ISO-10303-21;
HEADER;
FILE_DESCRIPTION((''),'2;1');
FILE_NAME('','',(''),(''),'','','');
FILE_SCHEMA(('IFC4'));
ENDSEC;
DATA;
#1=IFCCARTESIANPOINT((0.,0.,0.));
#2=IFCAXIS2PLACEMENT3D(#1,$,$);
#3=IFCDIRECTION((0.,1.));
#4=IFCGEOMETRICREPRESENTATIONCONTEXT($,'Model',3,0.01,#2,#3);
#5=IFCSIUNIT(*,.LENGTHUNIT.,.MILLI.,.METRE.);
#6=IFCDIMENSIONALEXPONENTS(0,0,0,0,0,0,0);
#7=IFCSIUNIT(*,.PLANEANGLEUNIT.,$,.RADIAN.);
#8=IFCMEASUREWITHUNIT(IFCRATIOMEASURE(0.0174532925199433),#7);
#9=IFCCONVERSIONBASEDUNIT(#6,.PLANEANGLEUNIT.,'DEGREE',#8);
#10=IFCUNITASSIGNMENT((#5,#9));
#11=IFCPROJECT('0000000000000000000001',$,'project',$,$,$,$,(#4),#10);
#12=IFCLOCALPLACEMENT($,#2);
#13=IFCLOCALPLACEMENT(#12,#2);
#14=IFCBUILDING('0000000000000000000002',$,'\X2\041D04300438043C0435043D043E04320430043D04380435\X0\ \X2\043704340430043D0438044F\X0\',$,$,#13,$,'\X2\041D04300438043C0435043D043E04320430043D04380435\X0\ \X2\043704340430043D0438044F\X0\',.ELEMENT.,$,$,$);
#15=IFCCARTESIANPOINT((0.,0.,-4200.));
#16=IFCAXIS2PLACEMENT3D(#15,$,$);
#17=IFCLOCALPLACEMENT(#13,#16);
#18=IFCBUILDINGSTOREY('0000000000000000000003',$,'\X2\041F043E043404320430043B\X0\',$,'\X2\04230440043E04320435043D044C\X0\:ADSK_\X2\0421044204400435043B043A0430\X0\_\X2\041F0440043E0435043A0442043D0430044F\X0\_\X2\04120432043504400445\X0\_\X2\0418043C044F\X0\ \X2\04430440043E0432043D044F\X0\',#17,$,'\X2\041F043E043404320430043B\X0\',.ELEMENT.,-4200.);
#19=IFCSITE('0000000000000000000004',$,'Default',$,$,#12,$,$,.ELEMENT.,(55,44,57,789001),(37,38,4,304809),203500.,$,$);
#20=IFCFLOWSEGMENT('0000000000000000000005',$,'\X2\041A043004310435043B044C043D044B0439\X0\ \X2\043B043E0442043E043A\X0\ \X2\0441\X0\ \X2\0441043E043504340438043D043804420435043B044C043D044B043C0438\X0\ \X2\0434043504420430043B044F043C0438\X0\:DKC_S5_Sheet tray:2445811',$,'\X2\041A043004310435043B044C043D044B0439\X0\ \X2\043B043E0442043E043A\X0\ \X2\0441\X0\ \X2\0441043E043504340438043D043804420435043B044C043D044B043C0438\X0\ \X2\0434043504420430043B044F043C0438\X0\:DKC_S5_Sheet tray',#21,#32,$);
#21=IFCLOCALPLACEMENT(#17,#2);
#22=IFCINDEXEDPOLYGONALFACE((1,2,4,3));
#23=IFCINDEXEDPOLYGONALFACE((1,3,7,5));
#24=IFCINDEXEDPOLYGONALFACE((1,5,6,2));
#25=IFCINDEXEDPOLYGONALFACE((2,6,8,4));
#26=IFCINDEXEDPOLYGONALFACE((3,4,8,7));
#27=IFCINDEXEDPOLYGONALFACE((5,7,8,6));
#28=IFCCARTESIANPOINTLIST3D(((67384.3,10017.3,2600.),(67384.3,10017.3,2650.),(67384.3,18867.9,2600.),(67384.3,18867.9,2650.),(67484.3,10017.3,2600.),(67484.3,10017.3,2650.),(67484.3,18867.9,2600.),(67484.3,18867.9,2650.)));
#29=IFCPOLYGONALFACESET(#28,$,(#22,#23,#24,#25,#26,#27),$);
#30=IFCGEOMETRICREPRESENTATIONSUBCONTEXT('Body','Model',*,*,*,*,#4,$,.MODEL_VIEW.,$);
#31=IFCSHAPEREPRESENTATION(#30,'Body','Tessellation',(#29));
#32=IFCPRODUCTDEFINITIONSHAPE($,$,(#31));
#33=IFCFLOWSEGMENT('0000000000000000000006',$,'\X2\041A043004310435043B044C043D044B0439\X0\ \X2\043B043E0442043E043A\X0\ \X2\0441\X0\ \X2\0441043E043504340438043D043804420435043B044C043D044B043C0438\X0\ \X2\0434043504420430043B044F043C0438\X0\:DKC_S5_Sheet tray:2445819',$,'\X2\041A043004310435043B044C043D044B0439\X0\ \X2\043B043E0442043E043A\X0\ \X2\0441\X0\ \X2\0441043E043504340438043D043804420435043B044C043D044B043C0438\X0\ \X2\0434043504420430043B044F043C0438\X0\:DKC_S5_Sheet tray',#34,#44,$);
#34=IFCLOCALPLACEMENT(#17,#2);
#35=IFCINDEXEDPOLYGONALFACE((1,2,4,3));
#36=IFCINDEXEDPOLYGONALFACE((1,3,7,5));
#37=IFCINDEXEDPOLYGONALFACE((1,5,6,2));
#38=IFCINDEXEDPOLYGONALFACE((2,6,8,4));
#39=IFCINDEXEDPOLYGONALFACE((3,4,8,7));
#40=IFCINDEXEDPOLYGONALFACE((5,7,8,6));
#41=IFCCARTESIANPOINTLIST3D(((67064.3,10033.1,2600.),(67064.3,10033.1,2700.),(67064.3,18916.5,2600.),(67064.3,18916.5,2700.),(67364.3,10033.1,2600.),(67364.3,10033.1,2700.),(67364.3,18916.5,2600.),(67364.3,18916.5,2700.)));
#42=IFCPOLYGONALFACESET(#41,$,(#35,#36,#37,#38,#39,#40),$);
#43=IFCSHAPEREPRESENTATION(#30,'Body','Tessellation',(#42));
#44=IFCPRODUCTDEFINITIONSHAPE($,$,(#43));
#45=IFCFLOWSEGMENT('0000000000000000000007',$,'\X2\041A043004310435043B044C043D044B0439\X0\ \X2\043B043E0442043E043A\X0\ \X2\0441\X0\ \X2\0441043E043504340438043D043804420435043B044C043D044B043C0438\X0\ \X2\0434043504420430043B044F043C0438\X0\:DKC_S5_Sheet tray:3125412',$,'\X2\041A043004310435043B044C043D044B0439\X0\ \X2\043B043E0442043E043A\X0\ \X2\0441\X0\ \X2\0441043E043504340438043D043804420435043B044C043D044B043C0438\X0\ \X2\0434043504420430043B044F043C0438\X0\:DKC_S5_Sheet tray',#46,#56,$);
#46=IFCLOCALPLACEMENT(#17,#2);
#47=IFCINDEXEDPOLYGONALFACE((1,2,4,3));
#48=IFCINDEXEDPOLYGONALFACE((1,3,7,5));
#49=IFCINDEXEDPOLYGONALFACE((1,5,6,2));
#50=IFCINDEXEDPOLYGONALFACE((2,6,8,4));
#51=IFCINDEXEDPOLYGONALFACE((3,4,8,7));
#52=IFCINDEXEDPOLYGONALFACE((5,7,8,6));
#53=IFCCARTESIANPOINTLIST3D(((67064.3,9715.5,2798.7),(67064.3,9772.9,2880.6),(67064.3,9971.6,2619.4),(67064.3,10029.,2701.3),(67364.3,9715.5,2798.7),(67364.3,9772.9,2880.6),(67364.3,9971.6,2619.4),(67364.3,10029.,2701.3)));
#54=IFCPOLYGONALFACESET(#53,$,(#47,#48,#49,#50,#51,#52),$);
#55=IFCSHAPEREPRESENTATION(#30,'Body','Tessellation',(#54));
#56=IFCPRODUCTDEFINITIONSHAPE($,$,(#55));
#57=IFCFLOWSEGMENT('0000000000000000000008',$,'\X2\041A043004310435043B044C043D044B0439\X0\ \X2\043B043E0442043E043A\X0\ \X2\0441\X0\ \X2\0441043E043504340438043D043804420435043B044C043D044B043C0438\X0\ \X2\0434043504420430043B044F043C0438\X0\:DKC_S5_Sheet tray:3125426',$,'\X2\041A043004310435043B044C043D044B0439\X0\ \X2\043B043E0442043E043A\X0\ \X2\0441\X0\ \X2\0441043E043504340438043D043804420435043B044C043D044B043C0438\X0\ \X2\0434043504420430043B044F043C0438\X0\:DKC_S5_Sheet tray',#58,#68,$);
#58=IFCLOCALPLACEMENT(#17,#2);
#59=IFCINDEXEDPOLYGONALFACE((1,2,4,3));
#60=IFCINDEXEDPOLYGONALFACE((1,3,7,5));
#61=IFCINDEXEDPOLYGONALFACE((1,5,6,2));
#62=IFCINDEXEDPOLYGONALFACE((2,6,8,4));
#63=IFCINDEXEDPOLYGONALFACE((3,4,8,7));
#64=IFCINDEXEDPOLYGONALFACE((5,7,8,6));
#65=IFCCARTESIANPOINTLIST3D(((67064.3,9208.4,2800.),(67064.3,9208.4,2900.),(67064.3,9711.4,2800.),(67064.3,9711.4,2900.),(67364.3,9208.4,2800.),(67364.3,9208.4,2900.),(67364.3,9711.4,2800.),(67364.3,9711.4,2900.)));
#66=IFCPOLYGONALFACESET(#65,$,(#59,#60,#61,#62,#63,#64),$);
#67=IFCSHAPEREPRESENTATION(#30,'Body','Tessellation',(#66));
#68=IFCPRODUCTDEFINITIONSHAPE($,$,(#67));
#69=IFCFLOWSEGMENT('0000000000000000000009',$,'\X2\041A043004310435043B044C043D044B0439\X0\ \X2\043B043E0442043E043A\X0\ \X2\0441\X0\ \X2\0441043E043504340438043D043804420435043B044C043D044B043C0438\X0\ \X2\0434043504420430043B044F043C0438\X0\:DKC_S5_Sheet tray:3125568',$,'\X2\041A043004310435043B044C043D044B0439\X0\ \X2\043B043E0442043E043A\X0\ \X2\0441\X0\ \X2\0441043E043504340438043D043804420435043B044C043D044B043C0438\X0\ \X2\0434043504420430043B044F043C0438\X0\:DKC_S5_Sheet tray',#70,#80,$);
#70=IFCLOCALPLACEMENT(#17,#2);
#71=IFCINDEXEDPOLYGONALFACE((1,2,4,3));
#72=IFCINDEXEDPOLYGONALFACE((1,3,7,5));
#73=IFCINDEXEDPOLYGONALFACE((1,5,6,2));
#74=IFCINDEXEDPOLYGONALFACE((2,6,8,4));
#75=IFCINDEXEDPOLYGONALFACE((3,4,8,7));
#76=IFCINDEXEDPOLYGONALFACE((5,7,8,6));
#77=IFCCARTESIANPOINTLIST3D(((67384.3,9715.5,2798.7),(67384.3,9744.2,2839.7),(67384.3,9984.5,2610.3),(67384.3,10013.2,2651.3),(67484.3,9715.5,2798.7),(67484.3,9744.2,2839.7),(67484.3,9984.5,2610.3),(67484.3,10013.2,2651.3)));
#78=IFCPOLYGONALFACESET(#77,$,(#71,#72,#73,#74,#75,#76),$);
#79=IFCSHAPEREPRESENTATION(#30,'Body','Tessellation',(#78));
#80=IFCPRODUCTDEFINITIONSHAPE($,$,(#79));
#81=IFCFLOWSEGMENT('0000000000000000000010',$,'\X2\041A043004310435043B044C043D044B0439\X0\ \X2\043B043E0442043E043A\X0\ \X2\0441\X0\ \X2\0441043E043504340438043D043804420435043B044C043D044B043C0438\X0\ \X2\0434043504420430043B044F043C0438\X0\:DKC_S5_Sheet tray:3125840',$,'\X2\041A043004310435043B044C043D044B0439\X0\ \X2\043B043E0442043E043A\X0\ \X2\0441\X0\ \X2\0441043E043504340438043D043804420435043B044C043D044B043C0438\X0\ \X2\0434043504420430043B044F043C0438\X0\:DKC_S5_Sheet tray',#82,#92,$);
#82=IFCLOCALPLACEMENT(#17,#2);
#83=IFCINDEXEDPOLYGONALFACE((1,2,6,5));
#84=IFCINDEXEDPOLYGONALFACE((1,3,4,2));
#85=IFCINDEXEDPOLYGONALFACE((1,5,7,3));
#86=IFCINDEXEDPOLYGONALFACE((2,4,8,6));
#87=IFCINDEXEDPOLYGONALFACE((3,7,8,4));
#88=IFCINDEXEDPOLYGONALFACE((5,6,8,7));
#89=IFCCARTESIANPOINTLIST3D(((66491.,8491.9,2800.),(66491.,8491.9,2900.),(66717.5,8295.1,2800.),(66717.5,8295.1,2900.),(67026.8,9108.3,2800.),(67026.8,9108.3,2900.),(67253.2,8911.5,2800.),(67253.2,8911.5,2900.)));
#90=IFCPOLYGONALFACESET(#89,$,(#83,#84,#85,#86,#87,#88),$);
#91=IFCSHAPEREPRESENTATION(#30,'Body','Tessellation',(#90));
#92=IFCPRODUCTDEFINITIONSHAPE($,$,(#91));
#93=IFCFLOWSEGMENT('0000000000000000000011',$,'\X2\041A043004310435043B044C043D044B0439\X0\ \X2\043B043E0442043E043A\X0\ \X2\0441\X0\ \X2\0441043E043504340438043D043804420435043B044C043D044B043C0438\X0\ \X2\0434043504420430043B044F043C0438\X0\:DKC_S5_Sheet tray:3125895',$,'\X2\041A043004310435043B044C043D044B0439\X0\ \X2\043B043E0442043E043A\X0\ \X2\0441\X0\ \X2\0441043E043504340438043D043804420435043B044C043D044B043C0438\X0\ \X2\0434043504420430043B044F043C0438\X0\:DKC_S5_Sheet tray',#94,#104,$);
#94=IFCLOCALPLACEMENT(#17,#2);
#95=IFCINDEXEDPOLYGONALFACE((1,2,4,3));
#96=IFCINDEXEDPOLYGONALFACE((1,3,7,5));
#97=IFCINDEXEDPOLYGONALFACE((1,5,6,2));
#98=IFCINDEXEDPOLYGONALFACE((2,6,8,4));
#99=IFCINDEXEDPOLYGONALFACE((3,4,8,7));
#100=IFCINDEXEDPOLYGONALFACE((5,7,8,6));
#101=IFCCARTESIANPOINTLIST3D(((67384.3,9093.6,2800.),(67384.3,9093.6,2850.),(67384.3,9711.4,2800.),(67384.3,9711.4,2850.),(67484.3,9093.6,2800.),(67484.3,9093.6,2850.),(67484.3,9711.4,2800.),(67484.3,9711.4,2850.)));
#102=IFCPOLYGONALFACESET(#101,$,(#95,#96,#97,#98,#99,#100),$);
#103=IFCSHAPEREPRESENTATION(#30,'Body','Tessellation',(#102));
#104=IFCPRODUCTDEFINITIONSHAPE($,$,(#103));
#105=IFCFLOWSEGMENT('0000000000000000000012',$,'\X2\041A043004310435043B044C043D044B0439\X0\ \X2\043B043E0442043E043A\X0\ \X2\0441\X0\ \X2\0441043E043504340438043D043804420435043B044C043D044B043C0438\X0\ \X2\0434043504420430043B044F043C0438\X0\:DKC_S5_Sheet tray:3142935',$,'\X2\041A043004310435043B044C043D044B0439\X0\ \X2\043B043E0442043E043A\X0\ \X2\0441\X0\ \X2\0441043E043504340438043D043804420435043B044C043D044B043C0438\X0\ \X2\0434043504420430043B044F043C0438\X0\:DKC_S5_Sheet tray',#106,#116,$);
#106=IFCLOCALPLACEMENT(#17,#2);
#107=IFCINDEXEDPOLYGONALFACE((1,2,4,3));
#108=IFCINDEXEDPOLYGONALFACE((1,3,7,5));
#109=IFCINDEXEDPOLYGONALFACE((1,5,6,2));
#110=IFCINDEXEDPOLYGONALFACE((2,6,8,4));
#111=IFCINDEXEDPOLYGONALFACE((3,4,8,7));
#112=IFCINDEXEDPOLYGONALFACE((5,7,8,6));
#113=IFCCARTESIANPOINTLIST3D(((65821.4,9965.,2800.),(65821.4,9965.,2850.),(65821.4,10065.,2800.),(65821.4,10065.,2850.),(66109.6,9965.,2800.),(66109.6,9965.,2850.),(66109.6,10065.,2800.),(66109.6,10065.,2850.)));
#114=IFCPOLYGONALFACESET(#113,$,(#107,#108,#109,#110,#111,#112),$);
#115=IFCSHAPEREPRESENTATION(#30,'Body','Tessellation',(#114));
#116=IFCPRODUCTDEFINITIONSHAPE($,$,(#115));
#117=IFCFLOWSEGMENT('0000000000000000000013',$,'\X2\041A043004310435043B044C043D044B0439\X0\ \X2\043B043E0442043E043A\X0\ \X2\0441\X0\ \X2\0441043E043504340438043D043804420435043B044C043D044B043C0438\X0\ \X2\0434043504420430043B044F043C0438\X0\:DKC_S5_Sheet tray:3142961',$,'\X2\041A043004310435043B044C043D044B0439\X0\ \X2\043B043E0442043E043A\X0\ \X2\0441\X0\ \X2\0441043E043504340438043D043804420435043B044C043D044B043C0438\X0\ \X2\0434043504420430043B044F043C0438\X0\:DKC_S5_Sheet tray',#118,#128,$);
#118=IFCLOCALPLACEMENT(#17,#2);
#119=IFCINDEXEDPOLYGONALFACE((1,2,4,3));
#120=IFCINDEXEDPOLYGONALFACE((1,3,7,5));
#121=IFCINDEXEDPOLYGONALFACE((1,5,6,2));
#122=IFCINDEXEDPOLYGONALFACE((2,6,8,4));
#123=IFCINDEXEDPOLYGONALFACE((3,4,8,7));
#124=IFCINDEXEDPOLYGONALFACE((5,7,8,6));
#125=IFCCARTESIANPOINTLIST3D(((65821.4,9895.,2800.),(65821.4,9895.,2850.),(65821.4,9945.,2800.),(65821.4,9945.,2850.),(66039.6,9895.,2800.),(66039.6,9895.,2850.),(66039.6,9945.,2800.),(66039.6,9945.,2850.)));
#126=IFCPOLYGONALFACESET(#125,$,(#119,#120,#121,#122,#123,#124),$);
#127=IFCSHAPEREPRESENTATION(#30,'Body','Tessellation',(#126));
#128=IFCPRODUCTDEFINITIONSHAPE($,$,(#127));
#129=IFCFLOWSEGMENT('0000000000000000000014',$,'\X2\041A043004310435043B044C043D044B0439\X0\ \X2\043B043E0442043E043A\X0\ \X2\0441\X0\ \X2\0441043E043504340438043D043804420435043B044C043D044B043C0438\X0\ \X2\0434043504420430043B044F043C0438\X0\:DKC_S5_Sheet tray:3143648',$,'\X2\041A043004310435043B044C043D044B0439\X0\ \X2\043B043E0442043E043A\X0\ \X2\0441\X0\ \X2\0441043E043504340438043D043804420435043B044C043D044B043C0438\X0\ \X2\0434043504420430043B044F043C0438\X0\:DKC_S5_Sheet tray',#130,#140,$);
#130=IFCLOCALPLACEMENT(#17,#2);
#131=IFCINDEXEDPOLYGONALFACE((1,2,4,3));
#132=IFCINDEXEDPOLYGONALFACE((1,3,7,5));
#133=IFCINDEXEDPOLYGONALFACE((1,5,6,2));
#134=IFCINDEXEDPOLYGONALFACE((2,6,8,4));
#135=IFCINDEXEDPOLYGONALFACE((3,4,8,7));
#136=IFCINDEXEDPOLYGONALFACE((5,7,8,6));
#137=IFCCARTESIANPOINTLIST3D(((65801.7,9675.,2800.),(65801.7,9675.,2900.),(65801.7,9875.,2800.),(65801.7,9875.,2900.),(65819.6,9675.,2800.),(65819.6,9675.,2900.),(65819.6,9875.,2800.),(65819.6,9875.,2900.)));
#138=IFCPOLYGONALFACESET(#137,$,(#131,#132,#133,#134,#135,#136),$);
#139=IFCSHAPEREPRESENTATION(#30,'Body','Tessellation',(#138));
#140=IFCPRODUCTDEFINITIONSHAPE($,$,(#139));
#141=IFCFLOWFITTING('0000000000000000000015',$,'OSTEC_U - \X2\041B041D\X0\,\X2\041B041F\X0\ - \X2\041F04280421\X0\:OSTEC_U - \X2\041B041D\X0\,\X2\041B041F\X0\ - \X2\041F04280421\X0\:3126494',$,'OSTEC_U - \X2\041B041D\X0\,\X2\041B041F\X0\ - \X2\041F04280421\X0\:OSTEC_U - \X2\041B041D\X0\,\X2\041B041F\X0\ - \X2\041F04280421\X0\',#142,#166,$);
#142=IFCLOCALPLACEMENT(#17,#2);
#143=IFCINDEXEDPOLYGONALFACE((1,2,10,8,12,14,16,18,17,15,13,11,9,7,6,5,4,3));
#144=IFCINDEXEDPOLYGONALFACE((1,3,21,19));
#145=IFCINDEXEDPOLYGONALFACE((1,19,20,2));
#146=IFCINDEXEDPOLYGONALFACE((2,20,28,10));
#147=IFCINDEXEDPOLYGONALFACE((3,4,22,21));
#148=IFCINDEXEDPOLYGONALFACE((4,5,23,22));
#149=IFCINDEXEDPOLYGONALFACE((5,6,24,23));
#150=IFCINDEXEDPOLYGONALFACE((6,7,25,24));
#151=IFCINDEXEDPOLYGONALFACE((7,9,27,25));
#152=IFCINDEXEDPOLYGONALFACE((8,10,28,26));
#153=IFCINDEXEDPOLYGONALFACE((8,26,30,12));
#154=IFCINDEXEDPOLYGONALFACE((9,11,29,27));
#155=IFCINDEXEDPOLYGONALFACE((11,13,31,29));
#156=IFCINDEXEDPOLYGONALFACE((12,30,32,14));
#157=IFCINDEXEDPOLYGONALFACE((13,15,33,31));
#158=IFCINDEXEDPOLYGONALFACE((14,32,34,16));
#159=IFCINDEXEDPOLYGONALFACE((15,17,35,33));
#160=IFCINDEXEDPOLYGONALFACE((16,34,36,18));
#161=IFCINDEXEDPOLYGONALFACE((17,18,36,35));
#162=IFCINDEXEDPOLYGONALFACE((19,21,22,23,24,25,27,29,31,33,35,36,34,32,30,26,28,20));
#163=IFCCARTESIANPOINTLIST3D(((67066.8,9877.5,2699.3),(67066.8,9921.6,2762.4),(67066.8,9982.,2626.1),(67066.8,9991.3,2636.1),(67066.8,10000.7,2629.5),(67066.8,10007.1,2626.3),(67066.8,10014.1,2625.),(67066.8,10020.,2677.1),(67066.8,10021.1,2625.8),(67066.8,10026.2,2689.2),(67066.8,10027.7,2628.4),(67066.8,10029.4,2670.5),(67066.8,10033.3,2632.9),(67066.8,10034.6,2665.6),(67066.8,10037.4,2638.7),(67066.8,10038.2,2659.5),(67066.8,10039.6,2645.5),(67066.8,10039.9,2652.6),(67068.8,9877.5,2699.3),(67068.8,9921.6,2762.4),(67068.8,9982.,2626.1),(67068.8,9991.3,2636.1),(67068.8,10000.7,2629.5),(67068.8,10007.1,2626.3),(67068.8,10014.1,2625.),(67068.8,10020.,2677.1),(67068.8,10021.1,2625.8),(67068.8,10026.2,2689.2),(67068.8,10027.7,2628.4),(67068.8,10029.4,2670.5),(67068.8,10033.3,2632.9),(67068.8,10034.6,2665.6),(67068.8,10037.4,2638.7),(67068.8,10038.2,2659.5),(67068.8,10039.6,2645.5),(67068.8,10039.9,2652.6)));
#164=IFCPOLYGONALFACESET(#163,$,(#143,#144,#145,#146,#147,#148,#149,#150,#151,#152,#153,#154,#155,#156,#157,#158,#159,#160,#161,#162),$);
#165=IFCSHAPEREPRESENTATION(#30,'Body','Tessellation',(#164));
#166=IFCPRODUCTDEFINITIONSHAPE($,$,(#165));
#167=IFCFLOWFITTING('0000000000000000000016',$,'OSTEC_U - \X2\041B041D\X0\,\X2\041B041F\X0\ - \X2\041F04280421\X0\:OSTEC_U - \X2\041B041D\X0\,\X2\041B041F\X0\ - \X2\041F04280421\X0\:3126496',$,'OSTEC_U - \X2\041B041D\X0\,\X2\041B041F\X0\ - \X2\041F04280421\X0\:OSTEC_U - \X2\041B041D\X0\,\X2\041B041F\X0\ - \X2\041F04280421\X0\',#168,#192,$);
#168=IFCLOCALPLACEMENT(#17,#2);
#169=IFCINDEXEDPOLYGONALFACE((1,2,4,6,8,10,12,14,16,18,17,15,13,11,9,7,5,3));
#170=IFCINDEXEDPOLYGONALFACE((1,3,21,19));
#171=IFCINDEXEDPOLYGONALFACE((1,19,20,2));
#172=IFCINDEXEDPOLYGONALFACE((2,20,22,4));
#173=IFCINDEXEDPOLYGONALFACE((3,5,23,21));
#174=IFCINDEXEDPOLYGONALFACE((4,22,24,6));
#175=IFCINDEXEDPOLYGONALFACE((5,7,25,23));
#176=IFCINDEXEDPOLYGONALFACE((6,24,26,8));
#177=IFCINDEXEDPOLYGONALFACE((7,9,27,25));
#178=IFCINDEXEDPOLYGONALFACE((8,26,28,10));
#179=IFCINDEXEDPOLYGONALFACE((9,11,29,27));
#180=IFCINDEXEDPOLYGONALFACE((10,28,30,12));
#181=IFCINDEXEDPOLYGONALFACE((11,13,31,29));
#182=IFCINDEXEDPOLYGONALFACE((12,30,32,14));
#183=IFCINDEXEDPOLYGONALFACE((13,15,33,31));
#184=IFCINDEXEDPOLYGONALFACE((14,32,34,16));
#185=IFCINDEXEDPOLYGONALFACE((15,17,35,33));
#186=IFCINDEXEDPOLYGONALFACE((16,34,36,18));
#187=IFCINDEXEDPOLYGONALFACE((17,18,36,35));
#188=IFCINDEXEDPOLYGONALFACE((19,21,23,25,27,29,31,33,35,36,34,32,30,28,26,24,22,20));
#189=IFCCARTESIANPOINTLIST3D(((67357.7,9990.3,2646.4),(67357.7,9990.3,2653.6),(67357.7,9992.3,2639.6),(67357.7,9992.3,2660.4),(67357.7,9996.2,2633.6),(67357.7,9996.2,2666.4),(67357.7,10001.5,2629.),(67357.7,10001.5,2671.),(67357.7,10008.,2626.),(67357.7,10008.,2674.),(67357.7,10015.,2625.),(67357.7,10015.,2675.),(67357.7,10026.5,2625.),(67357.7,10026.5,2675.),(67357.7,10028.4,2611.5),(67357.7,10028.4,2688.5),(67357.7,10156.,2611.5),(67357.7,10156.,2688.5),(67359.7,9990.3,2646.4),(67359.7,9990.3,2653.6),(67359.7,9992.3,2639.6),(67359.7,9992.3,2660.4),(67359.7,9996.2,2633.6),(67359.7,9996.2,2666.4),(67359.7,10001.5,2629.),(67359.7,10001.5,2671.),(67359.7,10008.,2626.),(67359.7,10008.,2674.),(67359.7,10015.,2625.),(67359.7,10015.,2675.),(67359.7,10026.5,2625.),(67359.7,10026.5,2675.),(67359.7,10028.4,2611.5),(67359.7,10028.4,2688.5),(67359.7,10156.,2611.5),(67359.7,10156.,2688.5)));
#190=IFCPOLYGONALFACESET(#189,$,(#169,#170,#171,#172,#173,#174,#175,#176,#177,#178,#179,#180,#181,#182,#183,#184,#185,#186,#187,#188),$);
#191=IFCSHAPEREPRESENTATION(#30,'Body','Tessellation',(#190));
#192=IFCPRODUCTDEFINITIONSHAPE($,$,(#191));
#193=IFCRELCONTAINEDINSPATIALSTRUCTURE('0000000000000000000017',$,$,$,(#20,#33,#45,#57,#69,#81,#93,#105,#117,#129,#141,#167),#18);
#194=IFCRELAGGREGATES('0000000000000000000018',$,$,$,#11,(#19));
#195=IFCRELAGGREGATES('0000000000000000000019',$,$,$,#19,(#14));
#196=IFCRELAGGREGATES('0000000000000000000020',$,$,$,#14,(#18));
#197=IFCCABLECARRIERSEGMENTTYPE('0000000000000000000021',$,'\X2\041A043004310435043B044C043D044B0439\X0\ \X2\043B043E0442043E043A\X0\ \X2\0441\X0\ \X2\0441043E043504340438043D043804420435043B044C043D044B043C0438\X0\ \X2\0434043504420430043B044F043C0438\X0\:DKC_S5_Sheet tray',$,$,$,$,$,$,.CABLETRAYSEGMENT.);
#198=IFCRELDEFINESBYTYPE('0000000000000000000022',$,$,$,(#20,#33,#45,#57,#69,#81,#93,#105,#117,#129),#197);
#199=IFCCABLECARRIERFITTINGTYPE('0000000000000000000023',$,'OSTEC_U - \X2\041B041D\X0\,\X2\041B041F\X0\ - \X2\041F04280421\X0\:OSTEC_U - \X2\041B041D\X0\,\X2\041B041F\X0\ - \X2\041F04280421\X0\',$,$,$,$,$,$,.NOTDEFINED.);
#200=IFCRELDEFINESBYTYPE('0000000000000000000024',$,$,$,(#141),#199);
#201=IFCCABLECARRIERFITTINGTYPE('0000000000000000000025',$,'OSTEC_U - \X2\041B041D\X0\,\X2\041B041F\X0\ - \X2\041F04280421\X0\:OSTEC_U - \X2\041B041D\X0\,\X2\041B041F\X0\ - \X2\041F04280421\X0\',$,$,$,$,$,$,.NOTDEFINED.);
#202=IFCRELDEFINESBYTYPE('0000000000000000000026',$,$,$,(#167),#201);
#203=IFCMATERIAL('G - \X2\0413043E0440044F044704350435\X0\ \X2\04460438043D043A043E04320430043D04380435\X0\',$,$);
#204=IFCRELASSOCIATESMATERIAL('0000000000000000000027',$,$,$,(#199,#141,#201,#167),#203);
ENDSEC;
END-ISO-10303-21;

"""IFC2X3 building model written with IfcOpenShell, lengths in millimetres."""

from ifc_helpers import new_model, entity, si_unit, converted_unit, direction, frame, frame_2d, origin, origin_2d_with_axis, place, context, subcontext, project, spatial, polyline, circle_curve, parameter, trimmed, segment, composite_curve, rectangle, outline, extrude, source, transform, mapped, material, type_object, type_shapes, element, save


model = new_model("IFC2X3")

# Units and contexts
model_context = context("Model", 3, precision=0.01, world=origin(), true_north=direction((0.0, 1.0)))
body_context = subcontext(model_context, "Body", "Model", "MODEL_VIEW")
ifc_project = project(units=[si_unit("LENGTHUNIT", "METRE", prefix="MILLI"), converted_unit("PLANEANGLEUNIT", "DEGREE", entity("IfcRatioMeasure", 0.0174532925199433), si_unit("PLANEANGLEUNIT", "RADIAN"), dimensions=[0, 0, 0, 0, 0, 0, 0])], contexts=[model_context])

# Site, building, storey
site_placement = place(None, origin())
site = spatial("IfcSite", under=ifc_project, at=site_placement, Name="Default", CompositionType="ELEMENT", RefLatitude=(55, 44, 57, 789001), RefLongitude=(37, 38, 4, 304809), RefElevation=203500.0)
building_placement = place(site_placement, origin())
building = spatial("IfcBuilding", under=site, at=building_placement, Name="Наименование здания", LongName="Наименование здания", CompositionType="ELEMENT")
storey_placement = place(building_placement, frame((0.0, 0.0, -4200.0)))
storey = spatial("IfcBuildingStorey", under=building, at=storey_placement, Name="Подвал", ObjectType="Уровень:ADSK_Стрелка_Проектная_Вверх_Имя уровня", LongName="Подвал", CompositionType="ELEMENT", Elevation=-4200.0)

# Flow segments
cable_carrier_segment_type = type_object("IfcCableCarrierSegmentType", Name="Кабельный лоток с соединительными деталями:DKC_S5_Sheet tray", PredefinedType="CABLETRAYSEGMENT")
flow_segment_1_placement = place(storey_placement, frame((67384.3, 10017.3, 2600.0)))
element("IfcFlowSegment", 1, at=flow_segment_1_placement, inside=storey, type_object=cable_carrier_segment_type, Name="Кабельный лоток с соединительными деталями:DKC_S5_Sheet tray:2445811", ObjectType="Кабельный лоток с соединительными деталями:DKC_S5_Sheet tray", context=body_context, shape_type="SweptSolid", body=[
    extrude(rectangle(XDim=8850.6, YDim=100.0, at=origin_2d_with_axis()), frame((50.0, 4425.3, 0.0), z_axis=(0.0, 0.0, 1.0), x_axis=(0.0, -1.0, 0.0)), (0.0, 0.0, 1.0), 50.0),
])
flow_segment_2_placement = place(storey_placement, frame((67064.3, 10033.1, 2600.0)))
element("IfcFlowSegment", 2, at=flow_segment_2_placement, inside=storey, type_object=cable_carrier_segment_type, Name="Кабельный лоток с соединительными деталями:DKC_S5_Sheet tray:2445819", ObjectType="Кабельный лоток с соединительными деталями:DKC_S5_Sheet tray", context=body_context, shape_type="SweptSolid", body=[
    extrude(rectangle(XDim=8883.5, YDim=300.0, at=origin_2d_with_axis()), frame((150.0, 4441.7, 0.0), z_axis=(0.0, 0.0, 1.0), x_axis=(0.0, 1.0, 0.0)), (0.0, 0.0, 1.0), 100.0),
])
flow_segment_3_placement = place(storey_placement, frame((67064.3, 9715.5, 2619.4)))
element("IfcFlowSegment", 3, at=flow_segment_3_placement, inside=storey, type_object=cable_carrier_segment_type, Name="Кабельный лоток с соединительными деталями:DKC_S5_Sheet tray:3125412", ObjectType="Кабельный лоток с соединительными деталями:DKC_S5_Sheet tray", context=body_context, shape_type="SweptSolid", body=[
    extrude(rectangle(XDim=100.0, YDim=312.6, at=frame_2d((0.0, 0.0), x_axis=(0.0, 1.0))), frame((0.0, 156.7, 130.6), z_axis=(1.0, 0.0, 0.0), x_axis=(0.0, -0.819152, 0.573576)), (0.0, 0.0, 1.0), 300.0),
])
flow_segment_4_placement = place(storey_placement, frame((67064.3, 9208.5, 2800.0)))
element("IfcFlowSegment", 4, at=flow_segment_4_placement, inside=storey, type_object=cable_carrier_segment_type, Name="Кабельный лоток с соединительными деталями:DKC_S5_Sheet tray:3125426", ObjectType="Кабельный лоток с соединительными деталями:DKC_S5_Sheet tray", context=body_context, shape_type="SweptSolid", body=[
    extrude(rectangle(XDim=502.9, YDim=300.0, at=origin_2d_with_axis()), frame((150.0, 251.5, 0.0), z_axis=(0.0, 0.0, 1.0), x_axis=(0.0, 1.0, 0.0)), (0.0, 0.0, 1.0), 100.0),
])
flow_segment_5_placement = place(storey_placement, frame((67384.3, 9715.5, 2610.3)))
element("IfcFlowSegment", 5, at=flow_segment_5_placement, inside=storey, type_object=cable_carrier_segment_type, Name="Кабельный лоток с соединительными деталями:DKC_S5_Sheet tray:3125568", ObjectType="Кабельный лоток с соединительными деталями:DKC_S5_Sheet tray", context=body_context, shape_type="SweptSolid", body=[
    extrude(rectangle(XDim=50.0, YDim=328.4, at=frame_2d((0.0, 0.0), x_axis=(0.0, 1.0))), frame((0.0, 148.8, 114.7), z_axis=(1.0, 0.0, 0.0), x_axis=(0.0, -0.819152, 0.573576)), (0.0, 0.0, 1.0), 100.0),
])
flow_segment_6_placement = place(storey_placement, frame((66491.0, 8295.1, 2800.0)))
element("IfcFlowSegment", 6, at=flow_segment_6_placement, inside=storey, type_object=cable_carrier_segment_type, Name="Кабельный лоток с соединительными деталями:DKC_S5_Sheet tray:3125840", ObjectType="Кабельный лоток с соединительными деталями:DKC_S5_Sheet tray", context=body_context, shape_type="SweptSolid", body=[
    extrude(rectangle(XDim=816.7, YDim=300.0, at=origin_2d_with_axis()), frame((381.1, 406.6, 0.0), z_axis=(0.0, 0.0, 1.0), x_axis=(-0.656059, -0.75471, 0.0)), (0.0, 0.0, 1.0), 100.0),
])
flow_segment_7_placement = place(storey_placement, frame((67384.3, 9093.6, 2800.0)))
element("IfcFlowSegment", 7, at=flow_segment_7_placement, inside=storey, type_object=cable_carrier_segment_type, Name="Кабельный лоток с соединительными деталями:DKC_S5_Sheet tray:3125895", ObjectType="Кабельный лоток с соединительными деталями:DKC_S5_Sheet tray", context=body_context, shape_type="SweptSolid", body=[
    extrude(rectangle(XDim=617.8, YDim=100.0, at=origin_2d_with_axis()), frame((50.0, 308.9, 0.0), z_axis=(0.0, 0.0, 1.0), x_axis=(0.0, 1.0, 0.0)), (0.0, 0.0, 1.0), 50.0),
])
flow_segment_8_placement = place(storey_placement, frame((65821.4, 9965.0, 2800.0)))
element("IfcFlowSegment", 8, at=flow_segment_8_placement, inside=storey, type_object=cable_carrier_segment_type, Name="Кабельный лоток с соединительными деталями:DKC_S5_Sheet tray:3142935", ObjectType="Кабельный лоток с соединительными деталями:DKC_S5_Sheet tray", context=body_context, shape_type="SweptSolid", body=[
    extrude(rectangle(XDim=288.2, YDim=100.0, at=origin_2d_with_axis()), frame((144.1, 50.0, 0.0), z_axis=(0.0, 0.0, 1.0), x_axis=(-1.0, 0.0, 0.0)), (0.0, 0.0, 1.0), 50.0),
])
flow_segment_9_placement = place(storey_placement, frame((65821.4, 9895.0, 2800.0)))
element("IfcFlowSegment", 9, at=flow_segment_9_placement, inside=storey, type_object=cable_carrier_segment_type, Name="Кабельный лоток с соединительными деталями:DKC_S5_Sheet tray:3142961", ObjectType="Кабельный лоток с соединительными деталями:DKC_S5_Sheet tray", context=body_context, shape_type="SweptSolid", body=[
    extrude(rectangle(XDim=218.2, YDim=50.0, at=origin_2d_with_axis()), frame((109.1, 25.0, 0.0)), (0.0, 0.0, 1.0), 50.0),
])
flow_segment_10_placement = place(storey_placement, frame((65801.8, 9675.0, 2800.0)))
element("IfcFlowSegment", 10, at=flow_segment_10_placement, inside=storey, type_object=cable_carrier_segment_type, Name="Кабельный лоток с соединительными деталями:DKC_S5_Sheet tray:3143648", ObjectType="Кабельный лоток с соединительными деталями:DKC_S5_Sheet tray", context=body_context, shape_type="SweptSolid", body=[
    extrude(rectangle(XDim=17.9, YDim=200.0, at=origin_2d_with_axis()), frame((8.9, 100.0, 0.0)), (0.0, 0.0, 1.0), 100.0),
])

# Flow fittings
ifc_material = material(Name="G - Горячее цинкование")
cable_carrier_fitting_type_1 = type_object("IfcCableCarrierFittingType", Name="OSTEC_U - ЛН,ЛП - ПШС:OSTEC_U - ЛН,ЛП - ПШС", PredefinedType="NOTDEFINED", material=ifc_material)
shared_shape_1 = source(origin(), body_context, "Body", "SweptSolid", [
    extrude(outline(composite_curve([segment(trimmed(circle_curve(frame_2d((-41.5, 0.0), x_axis=(1.0, 0.0)), 25.0), [parameter(90.0)], [parameter(270.0)], True, "PARAMETER"), True, "CONTINUOUS"), segment(polyline([(-41.5, -25.0), (-30.0, -25.0)]), True, "CONTINUOUS"), segment(polyline([(-30.0, -25.0), (-28.1, -38.5)]), True, "CONTINUOUS"), segment(polyline([(-28.1, -38.5), (99.5, -38.5)]), True, "CONTINUOUS"), segment(polyline([(99.5, -38.5), (99.5, 38.5)]), True, "CONTINUOUS"), segment(polyline([(99.5, 38.5), (-28.1, 38.5)]), True, "CONTINUOUS"), segment(polyline([(-28.1, 38.5), (-30.0, 25.0)]), True, "CONTINUOUS"), segment(polyline([(-30.0, 25.0), (-41.5, 25.0)]), True, "CONTINUOUS")], self_intersect=False)), frame((41.5, 0.0, 0.0), z_axis=(0.0, 0.0, -1.0), x_axis=(1.0, 0.0, 0.0)), (0.0, 0.0, -1.0), 2.0),
])
type_shapes(cable_carrier_fitting_type_1, [shared_shape_1])
flow_fitting_1_placement = place(storey_placement, frame((67068.8, 10015.0, 2650.0), z_axis=(-1.0, 0.0, 0.0), x_axis=(0.0, -0.819152, 0.573576)))
element("IfcFlowFitting", 11, at=flow_fitting_1_placement, inside=storey, type_object=cable_carrier_fitting_type_1, material=ifc_material, Name="OSTEC_U - ЛН,ЛП - ПШС:OSTEC_U - ЛН,ЛП - ПШС:3126494", ObjectType="OSTEC_U - ЛН,ЛП - ПШС:OSTEC_U - ЛН,ЛП - ПШС", context=body_context, shape_type="MappedRepresentation", body=[
    mapped(shared_shape_1, transform((0.0, 0.0, 0.0), scale=1.0)),
])
cable_carrier_fitting_type_2 = type_object("IfcCableCarrierFittingType", Name="OSTEC_U - ЛН,ЛП - ПШС:OSTEC_U - ЛН,ЛП - ПШС", PredefinedType="NOTDEFINED", material=ifc_material)
type_shapes(cable_carrier_fitting_type_2, [shared_shape_1])
flow_fitting_2_placement = place(storey_placement, frame((67357.7, 10015.0, 2650.0), z_axis=(1.0, 0.0, 0.0), x_axis=(0.0, 1.0, 0.0)))
element("IfcFlowFitting", 12, at=flow_fitting_2_placement, inside=storey, type_object=cable_carrier_fitting_type_2, material=ifc_material, Name="OSTEC_U - ЛН,ЛП - ПШС:OSTEC_U - ЛН,ЛП - ПШС:3126496", ObjectType="OSTEC_U - ЛН,ЛП - ПШС:OSTEC_U - ЛН,ЛП - ПШС", context=body_context, shape_type="MappedRepresentation", body=[
    mapped(shared_shape_1, transform((0.0, 0.0, 0.0), scale=1.0)),
])

save(model, "model.ifc")
